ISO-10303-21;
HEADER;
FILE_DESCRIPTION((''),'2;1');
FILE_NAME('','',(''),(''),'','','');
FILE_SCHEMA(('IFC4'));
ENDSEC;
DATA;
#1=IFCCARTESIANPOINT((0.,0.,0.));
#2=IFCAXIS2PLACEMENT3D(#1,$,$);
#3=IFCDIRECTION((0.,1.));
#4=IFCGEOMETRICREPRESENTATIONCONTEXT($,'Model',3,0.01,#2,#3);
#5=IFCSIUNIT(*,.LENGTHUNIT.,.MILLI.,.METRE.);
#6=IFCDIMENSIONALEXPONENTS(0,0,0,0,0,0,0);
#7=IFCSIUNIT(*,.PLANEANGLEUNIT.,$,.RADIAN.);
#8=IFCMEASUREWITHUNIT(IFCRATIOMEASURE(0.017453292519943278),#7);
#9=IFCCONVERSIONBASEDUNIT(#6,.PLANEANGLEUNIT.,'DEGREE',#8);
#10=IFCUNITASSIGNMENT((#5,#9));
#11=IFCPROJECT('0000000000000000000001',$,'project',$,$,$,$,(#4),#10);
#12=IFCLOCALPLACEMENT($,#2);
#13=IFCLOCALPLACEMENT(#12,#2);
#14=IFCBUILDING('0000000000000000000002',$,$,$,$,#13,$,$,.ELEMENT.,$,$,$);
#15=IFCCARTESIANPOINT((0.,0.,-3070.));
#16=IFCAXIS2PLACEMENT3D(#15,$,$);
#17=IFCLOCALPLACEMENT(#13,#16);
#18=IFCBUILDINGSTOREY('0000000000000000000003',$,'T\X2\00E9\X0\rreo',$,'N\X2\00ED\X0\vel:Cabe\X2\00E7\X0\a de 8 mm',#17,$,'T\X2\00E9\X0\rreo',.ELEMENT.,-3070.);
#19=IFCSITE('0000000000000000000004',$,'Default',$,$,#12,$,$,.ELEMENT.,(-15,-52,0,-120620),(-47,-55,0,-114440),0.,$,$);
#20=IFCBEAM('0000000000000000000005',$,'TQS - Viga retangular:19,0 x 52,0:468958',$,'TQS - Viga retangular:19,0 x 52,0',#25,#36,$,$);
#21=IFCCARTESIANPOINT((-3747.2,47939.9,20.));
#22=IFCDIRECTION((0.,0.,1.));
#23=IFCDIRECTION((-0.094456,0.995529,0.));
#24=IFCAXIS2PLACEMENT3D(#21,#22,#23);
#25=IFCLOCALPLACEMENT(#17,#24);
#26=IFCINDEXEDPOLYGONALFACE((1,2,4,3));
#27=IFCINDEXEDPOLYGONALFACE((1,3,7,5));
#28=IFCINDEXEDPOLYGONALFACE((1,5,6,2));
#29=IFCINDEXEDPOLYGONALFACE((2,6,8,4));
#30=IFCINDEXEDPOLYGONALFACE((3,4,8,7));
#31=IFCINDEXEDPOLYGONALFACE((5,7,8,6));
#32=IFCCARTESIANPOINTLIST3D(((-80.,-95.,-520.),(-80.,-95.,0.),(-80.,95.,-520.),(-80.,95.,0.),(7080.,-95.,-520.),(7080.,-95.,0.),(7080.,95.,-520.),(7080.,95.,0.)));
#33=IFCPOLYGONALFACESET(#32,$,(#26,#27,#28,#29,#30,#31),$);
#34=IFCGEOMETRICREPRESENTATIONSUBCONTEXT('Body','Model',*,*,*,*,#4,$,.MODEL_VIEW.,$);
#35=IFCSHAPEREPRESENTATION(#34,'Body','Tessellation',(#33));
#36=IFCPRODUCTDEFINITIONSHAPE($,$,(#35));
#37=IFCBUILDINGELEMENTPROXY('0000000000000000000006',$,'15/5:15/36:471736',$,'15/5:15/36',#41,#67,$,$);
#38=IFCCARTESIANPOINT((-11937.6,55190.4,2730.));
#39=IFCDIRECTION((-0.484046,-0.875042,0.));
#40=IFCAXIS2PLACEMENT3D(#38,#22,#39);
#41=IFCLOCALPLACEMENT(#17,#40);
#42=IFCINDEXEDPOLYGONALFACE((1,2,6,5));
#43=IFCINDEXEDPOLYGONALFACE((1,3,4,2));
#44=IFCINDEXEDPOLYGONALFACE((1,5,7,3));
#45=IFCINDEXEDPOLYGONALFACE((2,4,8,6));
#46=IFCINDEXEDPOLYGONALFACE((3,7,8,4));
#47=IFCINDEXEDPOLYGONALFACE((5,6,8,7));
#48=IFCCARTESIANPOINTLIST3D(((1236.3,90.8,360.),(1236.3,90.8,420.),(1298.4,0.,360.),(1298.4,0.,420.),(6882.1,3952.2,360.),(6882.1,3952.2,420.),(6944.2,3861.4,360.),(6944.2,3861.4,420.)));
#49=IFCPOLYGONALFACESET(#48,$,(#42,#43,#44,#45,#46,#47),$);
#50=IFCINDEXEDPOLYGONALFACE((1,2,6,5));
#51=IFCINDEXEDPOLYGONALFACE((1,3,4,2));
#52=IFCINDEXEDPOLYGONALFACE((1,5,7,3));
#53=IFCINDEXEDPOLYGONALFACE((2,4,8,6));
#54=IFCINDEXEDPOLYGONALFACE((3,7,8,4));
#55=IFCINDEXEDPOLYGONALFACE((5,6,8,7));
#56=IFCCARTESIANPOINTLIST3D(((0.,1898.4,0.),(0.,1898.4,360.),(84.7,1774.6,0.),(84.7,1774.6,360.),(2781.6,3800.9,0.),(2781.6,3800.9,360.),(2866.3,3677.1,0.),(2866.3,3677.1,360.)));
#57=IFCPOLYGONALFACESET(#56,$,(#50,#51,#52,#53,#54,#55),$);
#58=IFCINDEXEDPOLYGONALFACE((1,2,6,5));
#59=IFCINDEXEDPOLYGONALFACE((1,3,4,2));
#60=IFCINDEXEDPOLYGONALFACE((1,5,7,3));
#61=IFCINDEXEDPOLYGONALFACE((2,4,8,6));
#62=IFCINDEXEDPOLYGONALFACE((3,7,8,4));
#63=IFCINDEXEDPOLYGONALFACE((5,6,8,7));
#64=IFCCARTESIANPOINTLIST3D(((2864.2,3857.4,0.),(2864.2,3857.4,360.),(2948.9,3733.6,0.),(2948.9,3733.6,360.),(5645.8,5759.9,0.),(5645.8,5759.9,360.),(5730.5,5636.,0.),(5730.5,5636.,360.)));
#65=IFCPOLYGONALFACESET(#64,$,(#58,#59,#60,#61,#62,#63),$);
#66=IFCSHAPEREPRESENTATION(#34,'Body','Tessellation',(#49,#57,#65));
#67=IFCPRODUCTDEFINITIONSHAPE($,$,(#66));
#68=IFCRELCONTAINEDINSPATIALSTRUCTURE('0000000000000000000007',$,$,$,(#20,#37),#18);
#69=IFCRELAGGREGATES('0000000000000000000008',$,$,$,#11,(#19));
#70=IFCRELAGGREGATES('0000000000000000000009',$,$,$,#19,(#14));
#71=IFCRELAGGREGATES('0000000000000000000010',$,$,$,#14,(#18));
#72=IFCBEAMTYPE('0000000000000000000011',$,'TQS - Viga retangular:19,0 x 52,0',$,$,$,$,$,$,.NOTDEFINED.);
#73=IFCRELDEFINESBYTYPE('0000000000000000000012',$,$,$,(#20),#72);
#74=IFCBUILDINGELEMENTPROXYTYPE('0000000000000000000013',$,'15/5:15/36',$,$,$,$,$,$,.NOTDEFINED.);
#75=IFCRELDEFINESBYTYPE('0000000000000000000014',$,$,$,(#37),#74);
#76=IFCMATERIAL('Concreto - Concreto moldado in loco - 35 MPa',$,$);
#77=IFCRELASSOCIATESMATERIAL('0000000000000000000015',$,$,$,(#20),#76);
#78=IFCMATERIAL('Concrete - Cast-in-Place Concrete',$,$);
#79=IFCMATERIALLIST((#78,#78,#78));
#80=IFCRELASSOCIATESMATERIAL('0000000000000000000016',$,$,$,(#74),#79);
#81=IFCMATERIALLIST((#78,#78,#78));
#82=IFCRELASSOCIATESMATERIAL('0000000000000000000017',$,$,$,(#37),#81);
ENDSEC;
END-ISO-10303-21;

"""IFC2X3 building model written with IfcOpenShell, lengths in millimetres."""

from ifc_helpers import new_model, entity, si_unit, converted_unit, direction, frame, frame_2d, origin, place, context, subcontext, project, spatial, rectangle, extrude, source, transform, mapped, material, material_list, type_object, type_shapes, element, save


model = new_model("IFC2X3")

# Units and contexts
model_context = context("Model", 3, precision=0.01, world=origin(), true_north=direction((0.0, 1.0)))
body_context = subcontext(model_context, "Body", "Model", "MODEL_VIEW")
ifc_project = project(units=[si_unit("LENGTHUNIT", "METRE", prefix="MILLI"), converted_unit("PLANEANGLEUNIT", "DEGREE", entity("IfcRatioMeasure", 0.017453292519943278), si_unit("PLANEANGLEUNIT", "RADIAN"), dimensions=[0, 0, 0, 0, 0, 0, 0])], contexts=[model_context])

# Site, building, storey
site_placement = place(None, origin())
site = spatial("IfcSite", under=ifc_project, at=site_placement, Name="Default", CompositionType="ELEMENT", RefLatitude=(-15, -52, 0, -120620), RefLongitude=(-47, -55, 0, -114440), RefElevation=0.0)
building_placement = place(site_placement, origin())
building = spatial("IfcBuilding", under=site, at=building_placement, CompositionType="ELEMENT")
storey_placement = place(building_placement, frame((0.0, 0.0, -3070.0)))
storey = spatial("IfcBuildingStorey", under=building, at=storey_placement, Name="Térreo", ObjectType="Nível:Cabeça de 8 mm", LongName="Térreo", CompositionType="ELEMENT", Elevation=-3070.0)

# Beam
ifc_material_1 = material(Name="Concreto - Concreto moldado in loco - 35 MPa")
beam_type_1 = type_object("IfcBeamType", Name="TQS - Viga retangular:19,0 x 52,0", PredefinedType="NOTDEFINED")
beam_1_placement = place(storey_placement, frame((-3747.2, 47939.9, 20.0), z_axis=(0.0, 0.0, 1.0), x_axis=(-0.094456, 0.995529, 0.0)))
element("IfcBeam", 1, at=beam_1_placement, inside=storey, type_object=beam_type_1, material=ifc_material_1, Name="TQS - Viga retangular:19,0 x 52,0:468958", ObjectType="TQS - Viga retangular:19,0 x 52,0", context=body_context, shape_type="SweptSolid", body=[
    extrude(rectangle(XDim=520.0, YDim=190.0, at=frame_2d((0.0, 0.0), x_axis=(1.0, 0.0))), frame((-80.0, 0.0, -260.0), z_axis=(1.0, 0.0, 0.0), x_axis=(0.0, 0.0, -1.0)), (0.0, 0.0, 1.0), 7160.0),
])

# Building element proxy
ifc_material_2 = material(Name="Concrete - Cast-in-Place Concrete")
ifc_material_list_1 = material_list([ifc_material_2, ifc_material_2, ifc_material_2])
ifc_material_list_2 = material_list([ifc_material_2, ifc_material_2, ifc_material_2])
building_element_proxy_type = type_object("IfcBuildingElementProxyType", Name="15/5:15/36", PredefinedType="NOTDEFINED", material=ifc_material_list_2)
shared_shape = source(origin(), body_context, "Body", "SweptSolid", [
    extrude(rectangle(XDim=110.0, YDim=6840.0, at=frame_2d((0.0, 0.0), x_axis=(1.0, 0.0))), frame((4090.3, 1976.1, 360.0), z_axis=(0.0, 0.0, 1.0), x_axis=(-0.564535, 0.825409, 0.0)), (0.0, 0.0, 1.0), 60.0),
    extrude(rectangle(XDim=3370.0, YDim=150.0, at=frame_2d((0.0, 0.0), x_axis=(1.0, 0.0))), frame((1433.2, 2787.8, 0.0), z_axis=(0.0, 0.0, 1.0), x_axis=(0.825409, 0.564535, 0.0)), (0.0, 0.0, 1.0), 360.0),
    extrude(rectangle(XDim=3370.0, YDim=150.0, at=frame_2d((0.0, 0.0), x_axis=(1.0, 0.0))), frame((4297.3, 4746.7, 0.0), z_axis=(0.0, 0.0, 1.0), x_axis=(0.825409, 0.564535, 0.0)), (0.0, 0.0, 1.0), 360.0),
])
type_shapes(building_element_proxy_type, [shared_shape])
proxy_placement = place(storey_placement, frame((-11937.6, 55190.4, 2730.0), z_axis=(0.0, 0.0, 1.0), x_axis=(-0.484046, -0.875042, 0.0)))
element("IfcBuildingElementProxy", 2, at=proxy_placement, inside=storey, type_object=building_element_proxy_type, material=ifc_material_list_1, Name="15/5:15/36:471736", ObjectType="15/5:15/36", context=body_context, shape_type="MappedRepresentation", body=[
    mapped(shared_shape, transform((0.0, 0.0, 0.0), scale=1.0)),
])

save(model, "model.ifc")
